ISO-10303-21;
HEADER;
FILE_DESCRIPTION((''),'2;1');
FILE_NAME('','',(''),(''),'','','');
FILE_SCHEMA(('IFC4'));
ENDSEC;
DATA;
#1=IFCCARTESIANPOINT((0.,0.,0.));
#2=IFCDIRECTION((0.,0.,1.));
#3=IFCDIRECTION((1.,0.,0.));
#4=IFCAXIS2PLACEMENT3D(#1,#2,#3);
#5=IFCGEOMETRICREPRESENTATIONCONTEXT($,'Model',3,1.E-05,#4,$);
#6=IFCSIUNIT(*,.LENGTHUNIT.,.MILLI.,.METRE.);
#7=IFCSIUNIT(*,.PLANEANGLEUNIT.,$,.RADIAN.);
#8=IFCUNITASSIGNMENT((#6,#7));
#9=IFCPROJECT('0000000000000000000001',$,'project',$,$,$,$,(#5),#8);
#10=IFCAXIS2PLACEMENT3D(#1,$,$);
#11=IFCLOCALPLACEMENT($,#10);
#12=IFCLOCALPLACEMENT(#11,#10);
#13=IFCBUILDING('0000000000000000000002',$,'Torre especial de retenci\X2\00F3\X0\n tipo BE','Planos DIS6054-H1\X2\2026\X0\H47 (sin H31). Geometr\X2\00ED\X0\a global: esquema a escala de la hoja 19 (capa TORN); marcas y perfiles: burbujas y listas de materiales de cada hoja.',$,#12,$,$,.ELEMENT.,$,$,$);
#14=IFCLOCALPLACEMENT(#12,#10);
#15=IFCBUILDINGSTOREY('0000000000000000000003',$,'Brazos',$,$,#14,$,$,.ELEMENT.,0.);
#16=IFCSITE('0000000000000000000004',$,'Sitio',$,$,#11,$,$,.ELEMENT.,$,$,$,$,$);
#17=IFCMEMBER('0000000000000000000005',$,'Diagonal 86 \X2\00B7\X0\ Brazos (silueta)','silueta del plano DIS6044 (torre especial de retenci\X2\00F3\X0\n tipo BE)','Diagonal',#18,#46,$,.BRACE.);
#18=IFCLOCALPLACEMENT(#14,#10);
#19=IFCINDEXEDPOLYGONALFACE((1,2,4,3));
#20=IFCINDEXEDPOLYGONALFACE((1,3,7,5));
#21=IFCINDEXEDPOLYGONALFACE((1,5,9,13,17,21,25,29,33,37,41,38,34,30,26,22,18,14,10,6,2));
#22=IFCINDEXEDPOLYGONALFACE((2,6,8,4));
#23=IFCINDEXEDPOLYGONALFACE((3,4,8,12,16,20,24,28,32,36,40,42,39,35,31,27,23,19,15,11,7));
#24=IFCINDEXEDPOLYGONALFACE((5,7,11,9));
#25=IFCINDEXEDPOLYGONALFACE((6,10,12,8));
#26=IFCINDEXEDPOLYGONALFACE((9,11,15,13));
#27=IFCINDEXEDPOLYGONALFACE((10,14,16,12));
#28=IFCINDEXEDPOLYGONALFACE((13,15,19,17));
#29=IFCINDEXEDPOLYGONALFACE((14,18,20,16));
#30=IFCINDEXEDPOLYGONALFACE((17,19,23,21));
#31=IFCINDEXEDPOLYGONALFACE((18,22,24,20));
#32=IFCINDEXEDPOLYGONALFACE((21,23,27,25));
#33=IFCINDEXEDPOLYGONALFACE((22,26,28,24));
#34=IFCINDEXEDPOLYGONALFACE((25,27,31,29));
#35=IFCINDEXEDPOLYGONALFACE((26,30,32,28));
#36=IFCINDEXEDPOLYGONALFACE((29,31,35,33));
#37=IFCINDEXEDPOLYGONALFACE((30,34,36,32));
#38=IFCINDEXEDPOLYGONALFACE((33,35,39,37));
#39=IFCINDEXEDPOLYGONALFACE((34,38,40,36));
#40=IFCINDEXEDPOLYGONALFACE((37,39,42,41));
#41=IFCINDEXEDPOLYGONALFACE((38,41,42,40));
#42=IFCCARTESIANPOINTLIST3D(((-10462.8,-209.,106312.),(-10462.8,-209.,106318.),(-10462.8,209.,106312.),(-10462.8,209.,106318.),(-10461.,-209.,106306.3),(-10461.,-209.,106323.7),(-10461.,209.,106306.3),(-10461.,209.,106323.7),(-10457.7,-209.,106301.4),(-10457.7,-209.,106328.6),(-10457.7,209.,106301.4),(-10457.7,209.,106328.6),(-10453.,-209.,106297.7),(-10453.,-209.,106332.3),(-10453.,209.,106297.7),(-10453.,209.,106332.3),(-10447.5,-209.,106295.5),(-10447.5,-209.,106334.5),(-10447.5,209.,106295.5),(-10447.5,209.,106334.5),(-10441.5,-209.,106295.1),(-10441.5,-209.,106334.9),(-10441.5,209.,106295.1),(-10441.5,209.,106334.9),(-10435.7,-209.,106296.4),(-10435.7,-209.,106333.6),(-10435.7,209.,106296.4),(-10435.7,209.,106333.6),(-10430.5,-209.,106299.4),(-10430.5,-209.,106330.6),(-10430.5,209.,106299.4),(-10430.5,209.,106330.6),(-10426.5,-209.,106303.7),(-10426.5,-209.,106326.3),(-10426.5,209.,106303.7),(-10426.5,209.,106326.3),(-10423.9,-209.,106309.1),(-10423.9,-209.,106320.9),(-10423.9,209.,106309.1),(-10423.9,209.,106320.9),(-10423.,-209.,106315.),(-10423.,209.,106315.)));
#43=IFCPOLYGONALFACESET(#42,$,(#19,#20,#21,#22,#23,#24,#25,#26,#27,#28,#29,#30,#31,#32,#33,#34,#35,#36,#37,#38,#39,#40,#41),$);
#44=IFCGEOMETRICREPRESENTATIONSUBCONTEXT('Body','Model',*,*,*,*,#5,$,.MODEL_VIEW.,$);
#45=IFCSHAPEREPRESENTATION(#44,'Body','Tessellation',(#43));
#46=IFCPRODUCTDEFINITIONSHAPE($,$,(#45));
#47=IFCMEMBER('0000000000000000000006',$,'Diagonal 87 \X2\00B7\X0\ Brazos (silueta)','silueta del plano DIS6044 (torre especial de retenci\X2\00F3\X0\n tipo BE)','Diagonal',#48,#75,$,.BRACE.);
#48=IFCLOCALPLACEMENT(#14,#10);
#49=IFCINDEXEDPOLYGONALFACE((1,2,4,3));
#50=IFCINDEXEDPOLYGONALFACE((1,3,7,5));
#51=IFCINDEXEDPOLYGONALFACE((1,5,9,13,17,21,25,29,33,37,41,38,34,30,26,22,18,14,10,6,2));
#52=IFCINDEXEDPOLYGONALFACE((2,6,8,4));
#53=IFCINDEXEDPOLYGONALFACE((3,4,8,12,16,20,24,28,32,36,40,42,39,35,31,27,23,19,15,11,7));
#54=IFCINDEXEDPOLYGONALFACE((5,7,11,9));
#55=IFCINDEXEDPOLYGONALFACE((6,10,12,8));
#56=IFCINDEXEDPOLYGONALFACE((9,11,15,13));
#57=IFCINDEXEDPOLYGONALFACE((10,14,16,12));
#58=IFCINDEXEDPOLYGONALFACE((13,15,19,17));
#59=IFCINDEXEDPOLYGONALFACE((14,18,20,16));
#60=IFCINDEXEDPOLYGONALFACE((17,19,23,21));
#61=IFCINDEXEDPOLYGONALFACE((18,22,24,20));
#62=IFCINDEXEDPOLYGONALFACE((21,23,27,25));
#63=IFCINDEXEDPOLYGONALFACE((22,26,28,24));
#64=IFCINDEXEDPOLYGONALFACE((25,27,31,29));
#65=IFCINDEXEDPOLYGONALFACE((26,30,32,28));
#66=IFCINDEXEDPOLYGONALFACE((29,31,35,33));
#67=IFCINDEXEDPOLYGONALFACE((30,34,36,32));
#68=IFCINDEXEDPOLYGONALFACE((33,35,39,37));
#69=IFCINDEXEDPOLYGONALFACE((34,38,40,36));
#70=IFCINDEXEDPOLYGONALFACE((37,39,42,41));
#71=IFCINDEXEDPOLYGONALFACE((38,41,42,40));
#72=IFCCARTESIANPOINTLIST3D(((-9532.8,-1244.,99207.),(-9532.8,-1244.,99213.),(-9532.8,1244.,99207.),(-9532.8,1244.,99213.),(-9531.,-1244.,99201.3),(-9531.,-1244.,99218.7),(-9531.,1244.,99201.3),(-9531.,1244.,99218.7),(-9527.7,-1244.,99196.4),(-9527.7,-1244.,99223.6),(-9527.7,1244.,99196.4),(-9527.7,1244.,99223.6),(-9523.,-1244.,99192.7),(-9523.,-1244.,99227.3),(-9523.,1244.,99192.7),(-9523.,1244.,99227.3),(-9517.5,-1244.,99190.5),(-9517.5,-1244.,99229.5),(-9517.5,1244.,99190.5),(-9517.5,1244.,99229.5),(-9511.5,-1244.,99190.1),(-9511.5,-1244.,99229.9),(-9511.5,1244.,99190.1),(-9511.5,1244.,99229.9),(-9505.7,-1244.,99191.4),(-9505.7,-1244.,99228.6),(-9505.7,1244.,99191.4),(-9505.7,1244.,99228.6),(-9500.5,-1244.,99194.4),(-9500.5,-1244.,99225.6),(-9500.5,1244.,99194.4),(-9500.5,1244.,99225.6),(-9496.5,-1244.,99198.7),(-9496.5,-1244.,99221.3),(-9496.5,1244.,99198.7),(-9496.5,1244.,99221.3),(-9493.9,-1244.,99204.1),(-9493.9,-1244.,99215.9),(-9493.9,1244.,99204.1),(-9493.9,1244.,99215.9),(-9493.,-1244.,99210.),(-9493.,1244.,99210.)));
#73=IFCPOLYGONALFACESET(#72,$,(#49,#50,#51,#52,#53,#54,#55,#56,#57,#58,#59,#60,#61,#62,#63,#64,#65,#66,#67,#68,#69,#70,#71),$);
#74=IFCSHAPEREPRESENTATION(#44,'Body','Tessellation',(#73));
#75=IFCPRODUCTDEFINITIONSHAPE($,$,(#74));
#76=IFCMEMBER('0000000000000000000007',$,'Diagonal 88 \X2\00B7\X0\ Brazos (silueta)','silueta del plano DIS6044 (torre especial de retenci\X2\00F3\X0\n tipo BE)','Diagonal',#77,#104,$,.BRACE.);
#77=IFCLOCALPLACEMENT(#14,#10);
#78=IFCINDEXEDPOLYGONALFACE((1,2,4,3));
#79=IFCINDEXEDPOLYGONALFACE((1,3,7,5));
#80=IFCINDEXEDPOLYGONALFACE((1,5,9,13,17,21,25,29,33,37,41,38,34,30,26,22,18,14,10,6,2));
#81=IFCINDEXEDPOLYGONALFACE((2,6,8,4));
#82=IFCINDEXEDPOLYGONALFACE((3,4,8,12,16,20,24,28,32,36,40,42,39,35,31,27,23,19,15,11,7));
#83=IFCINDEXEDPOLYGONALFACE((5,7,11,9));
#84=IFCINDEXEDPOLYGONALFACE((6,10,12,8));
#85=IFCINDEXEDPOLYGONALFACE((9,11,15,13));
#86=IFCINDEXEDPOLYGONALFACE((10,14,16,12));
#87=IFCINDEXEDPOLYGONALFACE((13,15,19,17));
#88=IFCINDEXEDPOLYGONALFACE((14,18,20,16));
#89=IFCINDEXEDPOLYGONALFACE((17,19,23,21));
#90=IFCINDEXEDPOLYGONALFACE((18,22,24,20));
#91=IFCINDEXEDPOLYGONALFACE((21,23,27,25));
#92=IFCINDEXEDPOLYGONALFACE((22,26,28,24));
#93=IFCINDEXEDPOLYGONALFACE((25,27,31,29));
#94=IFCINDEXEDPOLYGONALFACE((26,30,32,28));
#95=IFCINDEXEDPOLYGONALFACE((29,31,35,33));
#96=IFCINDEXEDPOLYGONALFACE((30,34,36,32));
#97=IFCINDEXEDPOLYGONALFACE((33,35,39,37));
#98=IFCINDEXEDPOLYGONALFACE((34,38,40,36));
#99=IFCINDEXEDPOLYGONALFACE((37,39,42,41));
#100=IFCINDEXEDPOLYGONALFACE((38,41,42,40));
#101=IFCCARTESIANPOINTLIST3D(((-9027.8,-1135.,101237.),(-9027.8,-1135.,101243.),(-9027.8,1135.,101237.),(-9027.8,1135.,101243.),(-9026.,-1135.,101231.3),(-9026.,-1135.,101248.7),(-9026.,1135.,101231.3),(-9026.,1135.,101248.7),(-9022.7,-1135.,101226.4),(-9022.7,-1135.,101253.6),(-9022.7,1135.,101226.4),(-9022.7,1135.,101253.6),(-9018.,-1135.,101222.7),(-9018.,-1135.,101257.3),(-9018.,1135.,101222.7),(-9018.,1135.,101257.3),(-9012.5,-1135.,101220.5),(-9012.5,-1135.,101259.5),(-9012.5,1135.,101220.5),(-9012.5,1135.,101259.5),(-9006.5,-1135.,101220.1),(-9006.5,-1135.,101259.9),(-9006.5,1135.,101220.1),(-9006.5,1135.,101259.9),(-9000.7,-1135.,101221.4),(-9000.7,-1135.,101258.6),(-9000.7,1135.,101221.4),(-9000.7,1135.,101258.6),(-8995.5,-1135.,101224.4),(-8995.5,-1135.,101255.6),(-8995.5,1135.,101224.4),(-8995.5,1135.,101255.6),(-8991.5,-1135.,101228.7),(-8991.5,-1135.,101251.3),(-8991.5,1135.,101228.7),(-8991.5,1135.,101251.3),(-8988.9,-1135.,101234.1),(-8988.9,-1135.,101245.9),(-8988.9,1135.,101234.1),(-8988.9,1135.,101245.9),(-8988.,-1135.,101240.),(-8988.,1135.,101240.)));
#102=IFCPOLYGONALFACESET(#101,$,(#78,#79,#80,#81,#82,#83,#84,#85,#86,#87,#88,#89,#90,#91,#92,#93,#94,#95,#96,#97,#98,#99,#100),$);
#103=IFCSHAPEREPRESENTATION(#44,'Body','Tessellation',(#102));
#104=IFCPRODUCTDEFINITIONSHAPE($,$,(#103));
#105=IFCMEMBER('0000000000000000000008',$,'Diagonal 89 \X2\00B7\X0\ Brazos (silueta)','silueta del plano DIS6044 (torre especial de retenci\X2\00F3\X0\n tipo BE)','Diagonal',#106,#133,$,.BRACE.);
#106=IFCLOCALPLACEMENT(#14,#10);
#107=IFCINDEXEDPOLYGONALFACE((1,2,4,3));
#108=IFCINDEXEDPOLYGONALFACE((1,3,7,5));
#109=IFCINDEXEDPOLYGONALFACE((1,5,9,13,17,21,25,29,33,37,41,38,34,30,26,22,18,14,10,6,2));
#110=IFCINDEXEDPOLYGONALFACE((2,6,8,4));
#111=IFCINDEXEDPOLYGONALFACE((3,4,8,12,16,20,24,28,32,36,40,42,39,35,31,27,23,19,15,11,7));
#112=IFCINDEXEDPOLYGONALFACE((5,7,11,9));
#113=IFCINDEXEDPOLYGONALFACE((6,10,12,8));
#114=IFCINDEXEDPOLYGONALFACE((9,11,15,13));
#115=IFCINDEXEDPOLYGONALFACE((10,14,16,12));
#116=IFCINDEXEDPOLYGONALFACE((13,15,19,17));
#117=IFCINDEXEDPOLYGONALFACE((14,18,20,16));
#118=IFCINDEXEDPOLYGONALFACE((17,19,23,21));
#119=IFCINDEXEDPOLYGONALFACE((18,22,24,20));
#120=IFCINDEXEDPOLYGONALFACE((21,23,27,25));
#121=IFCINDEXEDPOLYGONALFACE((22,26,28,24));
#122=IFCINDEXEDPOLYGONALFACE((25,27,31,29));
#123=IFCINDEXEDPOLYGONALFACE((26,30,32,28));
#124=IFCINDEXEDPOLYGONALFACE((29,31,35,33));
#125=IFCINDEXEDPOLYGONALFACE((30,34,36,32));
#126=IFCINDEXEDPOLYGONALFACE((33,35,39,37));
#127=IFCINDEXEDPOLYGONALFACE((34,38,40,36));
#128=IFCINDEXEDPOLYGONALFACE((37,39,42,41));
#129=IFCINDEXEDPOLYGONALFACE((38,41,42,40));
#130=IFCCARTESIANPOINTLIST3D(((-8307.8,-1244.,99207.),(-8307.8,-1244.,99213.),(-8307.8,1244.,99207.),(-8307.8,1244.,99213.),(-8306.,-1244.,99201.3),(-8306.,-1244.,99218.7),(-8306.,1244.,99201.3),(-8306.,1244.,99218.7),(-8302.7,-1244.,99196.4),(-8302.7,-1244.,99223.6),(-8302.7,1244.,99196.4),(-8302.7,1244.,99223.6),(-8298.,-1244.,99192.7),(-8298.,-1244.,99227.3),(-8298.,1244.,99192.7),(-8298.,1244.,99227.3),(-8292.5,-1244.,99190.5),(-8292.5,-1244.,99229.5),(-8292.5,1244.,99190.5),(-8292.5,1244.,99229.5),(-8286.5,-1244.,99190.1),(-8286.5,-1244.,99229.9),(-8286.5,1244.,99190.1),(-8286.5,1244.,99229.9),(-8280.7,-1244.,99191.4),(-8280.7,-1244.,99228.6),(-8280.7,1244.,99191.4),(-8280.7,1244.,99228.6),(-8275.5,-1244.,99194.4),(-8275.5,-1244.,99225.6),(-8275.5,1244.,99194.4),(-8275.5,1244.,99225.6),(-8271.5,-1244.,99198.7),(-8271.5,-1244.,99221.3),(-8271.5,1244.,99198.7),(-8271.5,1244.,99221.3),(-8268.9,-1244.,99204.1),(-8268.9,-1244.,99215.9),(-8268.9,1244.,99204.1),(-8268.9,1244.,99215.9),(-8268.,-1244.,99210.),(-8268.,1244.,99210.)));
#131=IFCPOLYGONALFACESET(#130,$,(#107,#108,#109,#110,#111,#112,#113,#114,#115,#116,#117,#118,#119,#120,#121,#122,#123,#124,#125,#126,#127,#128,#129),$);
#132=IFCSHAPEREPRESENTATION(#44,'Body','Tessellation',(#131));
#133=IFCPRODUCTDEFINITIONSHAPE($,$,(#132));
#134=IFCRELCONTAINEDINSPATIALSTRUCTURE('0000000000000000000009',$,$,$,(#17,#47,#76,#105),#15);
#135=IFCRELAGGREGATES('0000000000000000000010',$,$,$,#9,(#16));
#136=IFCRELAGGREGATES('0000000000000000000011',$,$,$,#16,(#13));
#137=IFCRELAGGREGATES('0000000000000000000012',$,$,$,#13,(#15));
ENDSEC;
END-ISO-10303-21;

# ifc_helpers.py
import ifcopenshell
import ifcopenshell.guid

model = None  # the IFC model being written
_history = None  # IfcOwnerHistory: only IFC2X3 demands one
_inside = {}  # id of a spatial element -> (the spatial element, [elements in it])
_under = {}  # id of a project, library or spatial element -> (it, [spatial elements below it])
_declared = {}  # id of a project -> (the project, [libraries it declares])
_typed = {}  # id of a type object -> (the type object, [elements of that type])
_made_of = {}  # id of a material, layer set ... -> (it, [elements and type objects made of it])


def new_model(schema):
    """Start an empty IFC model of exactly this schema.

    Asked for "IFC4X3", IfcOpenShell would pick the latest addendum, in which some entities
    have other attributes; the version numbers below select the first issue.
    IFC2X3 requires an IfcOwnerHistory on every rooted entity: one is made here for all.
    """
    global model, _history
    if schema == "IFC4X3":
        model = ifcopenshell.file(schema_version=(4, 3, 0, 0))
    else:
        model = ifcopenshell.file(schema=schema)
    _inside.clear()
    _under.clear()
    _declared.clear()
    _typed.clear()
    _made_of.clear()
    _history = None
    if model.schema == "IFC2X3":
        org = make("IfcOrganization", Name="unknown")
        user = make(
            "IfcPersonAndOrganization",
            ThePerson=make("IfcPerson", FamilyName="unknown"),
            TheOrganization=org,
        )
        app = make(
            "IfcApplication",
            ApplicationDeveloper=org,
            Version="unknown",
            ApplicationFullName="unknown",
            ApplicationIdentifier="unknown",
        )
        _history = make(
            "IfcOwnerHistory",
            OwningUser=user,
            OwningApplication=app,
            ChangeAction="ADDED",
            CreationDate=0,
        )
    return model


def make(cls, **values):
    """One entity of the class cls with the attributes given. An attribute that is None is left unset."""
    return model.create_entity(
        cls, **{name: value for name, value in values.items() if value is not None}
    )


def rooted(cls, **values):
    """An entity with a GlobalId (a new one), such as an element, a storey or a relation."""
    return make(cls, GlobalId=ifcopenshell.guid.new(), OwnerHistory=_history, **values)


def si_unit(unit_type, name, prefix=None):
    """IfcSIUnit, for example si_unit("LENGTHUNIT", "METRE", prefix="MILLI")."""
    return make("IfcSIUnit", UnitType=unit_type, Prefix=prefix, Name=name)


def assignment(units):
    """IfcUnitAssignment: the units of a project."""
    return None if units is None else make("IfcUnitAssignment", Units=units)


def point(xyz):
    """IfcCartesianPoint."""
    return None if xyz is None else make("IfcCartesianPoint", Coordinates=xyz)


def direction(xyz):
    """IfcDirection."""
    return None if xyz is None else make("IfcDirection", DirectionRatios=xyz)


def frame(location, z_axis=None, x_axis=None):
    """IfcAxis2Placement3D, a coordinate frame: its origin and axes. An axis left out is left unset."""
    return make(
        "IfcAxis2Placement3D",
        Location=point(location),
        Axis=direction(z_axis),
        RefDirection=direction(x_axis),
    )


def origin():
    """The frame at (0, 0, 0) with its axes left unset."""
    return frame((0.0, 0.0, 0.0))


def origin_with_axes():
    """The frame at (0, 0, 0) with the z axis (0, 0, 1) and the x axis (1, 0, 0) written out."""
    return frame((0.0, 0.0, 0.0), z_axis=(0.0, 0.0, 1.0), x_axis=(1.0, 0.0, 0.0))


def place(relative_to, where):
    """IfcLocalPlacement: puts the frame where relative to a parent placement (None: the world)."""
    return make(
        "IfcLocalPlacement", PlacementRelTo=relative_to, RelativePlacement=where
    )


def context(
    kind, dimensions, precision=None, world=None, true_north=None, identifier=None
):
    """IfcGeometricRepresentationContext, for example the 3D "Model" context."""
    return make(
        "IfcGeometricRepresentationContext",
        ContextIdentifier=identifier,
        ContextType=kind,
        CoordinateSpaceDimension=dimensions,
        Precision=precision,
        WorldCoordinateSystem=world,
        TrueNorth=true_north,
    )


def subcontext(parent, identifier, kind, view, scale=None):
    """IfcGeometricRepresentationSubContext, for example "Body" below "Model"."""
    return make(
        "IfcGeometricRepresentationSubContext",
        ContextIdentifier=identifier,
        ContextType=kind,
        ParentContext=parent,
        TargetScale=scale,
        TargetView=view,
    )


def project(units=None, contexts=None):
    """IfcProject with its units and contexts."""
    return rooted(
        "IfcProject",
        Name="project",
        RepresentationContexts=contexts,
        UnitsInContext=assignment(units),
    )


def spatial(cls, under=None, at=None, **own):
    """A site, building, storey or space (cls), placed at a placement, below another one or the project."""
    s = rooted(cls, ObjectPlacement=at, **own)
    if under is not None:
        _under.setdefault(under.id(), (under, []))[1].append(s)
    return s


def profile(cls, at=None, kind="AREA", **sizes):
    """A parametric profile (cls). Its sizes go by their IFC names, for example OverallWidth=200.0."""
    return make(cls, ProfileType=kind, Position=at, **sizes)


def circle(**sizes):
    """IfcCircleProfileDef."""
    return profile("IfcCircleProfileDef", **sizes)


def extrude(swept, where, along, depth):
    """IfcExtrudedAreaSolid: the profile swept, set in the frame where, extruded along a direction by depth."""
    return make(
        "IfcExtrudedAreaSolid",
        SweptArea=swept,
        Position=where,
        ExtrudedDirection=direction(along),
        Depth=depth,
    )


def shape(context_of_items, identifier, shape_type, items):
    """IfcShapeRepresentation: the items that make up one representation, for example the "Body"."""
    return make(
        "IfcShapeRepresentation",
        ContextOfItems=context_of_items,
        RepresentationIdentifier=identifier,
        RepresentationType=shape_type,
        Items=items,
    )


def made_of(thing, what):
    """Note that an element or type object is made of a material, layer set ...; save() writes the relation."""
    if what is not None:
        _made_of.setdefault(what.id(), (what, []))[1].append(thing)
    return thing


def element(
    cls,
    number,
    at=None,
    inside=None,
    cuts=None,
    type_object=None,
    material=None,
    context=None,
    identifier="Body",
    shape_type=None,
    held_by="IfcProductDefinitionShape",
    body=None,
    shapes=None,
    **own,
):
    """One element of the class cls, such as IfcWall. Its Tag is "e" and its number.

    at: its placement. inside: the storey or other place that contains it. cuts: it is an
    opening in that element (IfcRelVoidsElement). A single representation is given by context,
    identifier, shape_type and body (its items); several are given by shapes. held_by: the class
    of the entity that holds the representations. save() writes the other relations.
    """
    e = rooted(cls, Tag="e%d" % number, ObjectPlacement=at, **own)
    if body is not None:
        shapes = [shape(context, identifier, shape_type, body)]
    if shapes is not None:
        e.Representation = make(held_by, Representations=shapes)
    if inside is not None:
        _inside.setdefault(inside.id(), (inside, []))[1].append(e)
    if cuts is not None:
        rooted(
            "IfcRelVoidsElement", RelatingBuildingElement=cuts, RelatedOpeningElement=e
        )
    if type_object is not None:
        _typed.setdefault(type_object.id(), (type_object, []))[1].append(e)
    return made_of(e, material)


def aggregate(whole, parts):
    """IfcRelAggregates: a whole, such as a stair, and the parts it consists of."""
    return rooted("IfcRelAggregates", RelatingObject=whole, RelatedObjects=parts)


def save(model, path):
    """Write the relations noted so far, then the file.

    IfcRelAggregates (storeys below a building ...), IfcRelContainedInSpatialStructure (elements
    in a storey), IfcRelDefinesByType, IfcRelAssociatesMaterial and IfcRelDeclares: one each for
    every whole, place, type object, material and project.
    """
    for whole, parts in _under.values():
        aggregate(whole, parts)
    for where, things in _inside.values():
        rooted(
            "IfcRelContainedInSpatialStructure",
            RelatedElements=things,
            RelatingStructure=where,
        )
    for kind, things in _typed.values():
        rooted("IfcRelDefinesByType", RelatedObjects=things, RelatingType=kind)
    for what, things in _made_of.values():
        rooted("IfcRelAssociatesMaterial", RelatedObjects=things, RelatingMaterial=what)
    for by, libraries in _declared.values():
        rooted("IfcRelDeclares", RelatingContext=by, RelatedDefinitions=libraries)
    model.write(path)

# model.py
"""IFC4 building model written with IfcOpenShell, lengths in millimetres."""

from ifc_helpers import new_model, si_unit, frame, origin, origin_with_axes, place, context, subcontext, project, spatial, circle, extrude, element, save


model = new_model("IFC4")

# Units and contexts
model_context = context("Model", 3, precision=1e-05, world=origin_with_axes())
body_context = subcontext(model_context, "Body", "Model", "MODEL_VIEW")
ifc_project = project(units=[si_unit("LENGTHUNIT", "METRE", prefix="MILLI"), si_unit("PLANEANGLEUNIT", "RADIAN")], contexts=[model_context])

# Site, building, storey
site_placement = place(None, origin())
site = spatial("IfcSite", under=ifc_project, at=site_placement, Name="Sitio", CompositionType="ELEMENT")
building_placement = place(site_placement, origin())
building = spatial("IfcBuilding", under=site, at=building_placement, Name="Torre especial de retención tipo BE", Description="Planos DIS6054-H1…H47 (sin H31). Geometría global: esquema a escala de la hoja 19 (capa TORN); marcas y perfiles: burbujas y listas de materiales de cada hoja.", CompositionType="ELEMENT")
storey_placement = place(building_placement, origin())
storey = spatial("IfcBuildingStorey", under=building, at=storey_placement, Name="Brazos", CompositionType="ELEMENT", Elevation=0.0)

# Members
member_1_placement = place(storey_placement, frame((-10443.0, 209.0, 106315.0), z_axis=(0.0, -1.0, 0.0), x_axis=(1.0, 0.0, 0.0)))
element("IfcMember", 1, at=member_1_placement, inside=storey, Name="Diagonal 86 · Brazos (silueta)", Description="silueta del plano DIS6044 (torre especial de retención tipo BE)", ObjectType="Diagonal", PredefinedType="BRACE", context=body_context, shape_type="SweptSolid", body=[
    extrude(circle(Radius=20.0), None, (0.0, 0.0, 1.0), 418.0),
])
member_2_placement = place(storey_placement, frame((-9513.0, 1244.0, 99210.0), z_axis=(0.0, -1.0, 0.0), x_axis=(1.0, 0.0, 0.0)))
element("IfcMember", 2, at=member_2_placement, inside=storey, Name="Diagonal 87 · Brazos (silueta)", Description="silueta del plano DIS6044 (torre especial de retención tipo BE)", ObjectType="Diagonal", PredefinedType="BRACE", context=body_context, shape_type="SweptSolid", body=[
    extrude(circle(Radius=20.0), None, (0.0, 0.0, 1.0), 2488.0),
])
member_3_placement = place(storey_placement, frame((-9008.0, 1135.0, 101240.0), z_axis=(0.0, -1.0, 0.0), x_axis=(1.0, 0.0, 0.0)))
element("IfcMember", 3, at=member_3_placement, inside=storey, Name="Diagonal 88 · Brazos (silueta)", Description="silueta del plano DIS6044 (torre especial de retención tipo BE)", ObjectType="Diagonal", PredefinedType="BRACE", context=body_context, shape_type="SweptSolid", body=[
    extrude(circle(Radius=20.0), None, (0.0, 0.0, 1.0), 2270.0),
])
member_4_placement = place(storey_placement, frame((-8288.0, 1244.0, 99210.0), z_axis=(0.0, -1.0, 0.0), x_axis=(1.0, 0.0, 0.0)))
element("IfcMember", 4, at=member_4_placement, inside=storey, Name="Diagonal 89 · Brazos (silueta)", Description="silueta del plano DIS6044 (torre especial de retención tipo BE)", ObjectType="Diagonal", PredefinedType="BRACE", context=body_context, shape_type="SweptSolid", body=[
    extrude(circle(Radius=20.0), None, (0.0, 0.0, 1.0), 2488.0),
])

save(model, "model.ifc")
